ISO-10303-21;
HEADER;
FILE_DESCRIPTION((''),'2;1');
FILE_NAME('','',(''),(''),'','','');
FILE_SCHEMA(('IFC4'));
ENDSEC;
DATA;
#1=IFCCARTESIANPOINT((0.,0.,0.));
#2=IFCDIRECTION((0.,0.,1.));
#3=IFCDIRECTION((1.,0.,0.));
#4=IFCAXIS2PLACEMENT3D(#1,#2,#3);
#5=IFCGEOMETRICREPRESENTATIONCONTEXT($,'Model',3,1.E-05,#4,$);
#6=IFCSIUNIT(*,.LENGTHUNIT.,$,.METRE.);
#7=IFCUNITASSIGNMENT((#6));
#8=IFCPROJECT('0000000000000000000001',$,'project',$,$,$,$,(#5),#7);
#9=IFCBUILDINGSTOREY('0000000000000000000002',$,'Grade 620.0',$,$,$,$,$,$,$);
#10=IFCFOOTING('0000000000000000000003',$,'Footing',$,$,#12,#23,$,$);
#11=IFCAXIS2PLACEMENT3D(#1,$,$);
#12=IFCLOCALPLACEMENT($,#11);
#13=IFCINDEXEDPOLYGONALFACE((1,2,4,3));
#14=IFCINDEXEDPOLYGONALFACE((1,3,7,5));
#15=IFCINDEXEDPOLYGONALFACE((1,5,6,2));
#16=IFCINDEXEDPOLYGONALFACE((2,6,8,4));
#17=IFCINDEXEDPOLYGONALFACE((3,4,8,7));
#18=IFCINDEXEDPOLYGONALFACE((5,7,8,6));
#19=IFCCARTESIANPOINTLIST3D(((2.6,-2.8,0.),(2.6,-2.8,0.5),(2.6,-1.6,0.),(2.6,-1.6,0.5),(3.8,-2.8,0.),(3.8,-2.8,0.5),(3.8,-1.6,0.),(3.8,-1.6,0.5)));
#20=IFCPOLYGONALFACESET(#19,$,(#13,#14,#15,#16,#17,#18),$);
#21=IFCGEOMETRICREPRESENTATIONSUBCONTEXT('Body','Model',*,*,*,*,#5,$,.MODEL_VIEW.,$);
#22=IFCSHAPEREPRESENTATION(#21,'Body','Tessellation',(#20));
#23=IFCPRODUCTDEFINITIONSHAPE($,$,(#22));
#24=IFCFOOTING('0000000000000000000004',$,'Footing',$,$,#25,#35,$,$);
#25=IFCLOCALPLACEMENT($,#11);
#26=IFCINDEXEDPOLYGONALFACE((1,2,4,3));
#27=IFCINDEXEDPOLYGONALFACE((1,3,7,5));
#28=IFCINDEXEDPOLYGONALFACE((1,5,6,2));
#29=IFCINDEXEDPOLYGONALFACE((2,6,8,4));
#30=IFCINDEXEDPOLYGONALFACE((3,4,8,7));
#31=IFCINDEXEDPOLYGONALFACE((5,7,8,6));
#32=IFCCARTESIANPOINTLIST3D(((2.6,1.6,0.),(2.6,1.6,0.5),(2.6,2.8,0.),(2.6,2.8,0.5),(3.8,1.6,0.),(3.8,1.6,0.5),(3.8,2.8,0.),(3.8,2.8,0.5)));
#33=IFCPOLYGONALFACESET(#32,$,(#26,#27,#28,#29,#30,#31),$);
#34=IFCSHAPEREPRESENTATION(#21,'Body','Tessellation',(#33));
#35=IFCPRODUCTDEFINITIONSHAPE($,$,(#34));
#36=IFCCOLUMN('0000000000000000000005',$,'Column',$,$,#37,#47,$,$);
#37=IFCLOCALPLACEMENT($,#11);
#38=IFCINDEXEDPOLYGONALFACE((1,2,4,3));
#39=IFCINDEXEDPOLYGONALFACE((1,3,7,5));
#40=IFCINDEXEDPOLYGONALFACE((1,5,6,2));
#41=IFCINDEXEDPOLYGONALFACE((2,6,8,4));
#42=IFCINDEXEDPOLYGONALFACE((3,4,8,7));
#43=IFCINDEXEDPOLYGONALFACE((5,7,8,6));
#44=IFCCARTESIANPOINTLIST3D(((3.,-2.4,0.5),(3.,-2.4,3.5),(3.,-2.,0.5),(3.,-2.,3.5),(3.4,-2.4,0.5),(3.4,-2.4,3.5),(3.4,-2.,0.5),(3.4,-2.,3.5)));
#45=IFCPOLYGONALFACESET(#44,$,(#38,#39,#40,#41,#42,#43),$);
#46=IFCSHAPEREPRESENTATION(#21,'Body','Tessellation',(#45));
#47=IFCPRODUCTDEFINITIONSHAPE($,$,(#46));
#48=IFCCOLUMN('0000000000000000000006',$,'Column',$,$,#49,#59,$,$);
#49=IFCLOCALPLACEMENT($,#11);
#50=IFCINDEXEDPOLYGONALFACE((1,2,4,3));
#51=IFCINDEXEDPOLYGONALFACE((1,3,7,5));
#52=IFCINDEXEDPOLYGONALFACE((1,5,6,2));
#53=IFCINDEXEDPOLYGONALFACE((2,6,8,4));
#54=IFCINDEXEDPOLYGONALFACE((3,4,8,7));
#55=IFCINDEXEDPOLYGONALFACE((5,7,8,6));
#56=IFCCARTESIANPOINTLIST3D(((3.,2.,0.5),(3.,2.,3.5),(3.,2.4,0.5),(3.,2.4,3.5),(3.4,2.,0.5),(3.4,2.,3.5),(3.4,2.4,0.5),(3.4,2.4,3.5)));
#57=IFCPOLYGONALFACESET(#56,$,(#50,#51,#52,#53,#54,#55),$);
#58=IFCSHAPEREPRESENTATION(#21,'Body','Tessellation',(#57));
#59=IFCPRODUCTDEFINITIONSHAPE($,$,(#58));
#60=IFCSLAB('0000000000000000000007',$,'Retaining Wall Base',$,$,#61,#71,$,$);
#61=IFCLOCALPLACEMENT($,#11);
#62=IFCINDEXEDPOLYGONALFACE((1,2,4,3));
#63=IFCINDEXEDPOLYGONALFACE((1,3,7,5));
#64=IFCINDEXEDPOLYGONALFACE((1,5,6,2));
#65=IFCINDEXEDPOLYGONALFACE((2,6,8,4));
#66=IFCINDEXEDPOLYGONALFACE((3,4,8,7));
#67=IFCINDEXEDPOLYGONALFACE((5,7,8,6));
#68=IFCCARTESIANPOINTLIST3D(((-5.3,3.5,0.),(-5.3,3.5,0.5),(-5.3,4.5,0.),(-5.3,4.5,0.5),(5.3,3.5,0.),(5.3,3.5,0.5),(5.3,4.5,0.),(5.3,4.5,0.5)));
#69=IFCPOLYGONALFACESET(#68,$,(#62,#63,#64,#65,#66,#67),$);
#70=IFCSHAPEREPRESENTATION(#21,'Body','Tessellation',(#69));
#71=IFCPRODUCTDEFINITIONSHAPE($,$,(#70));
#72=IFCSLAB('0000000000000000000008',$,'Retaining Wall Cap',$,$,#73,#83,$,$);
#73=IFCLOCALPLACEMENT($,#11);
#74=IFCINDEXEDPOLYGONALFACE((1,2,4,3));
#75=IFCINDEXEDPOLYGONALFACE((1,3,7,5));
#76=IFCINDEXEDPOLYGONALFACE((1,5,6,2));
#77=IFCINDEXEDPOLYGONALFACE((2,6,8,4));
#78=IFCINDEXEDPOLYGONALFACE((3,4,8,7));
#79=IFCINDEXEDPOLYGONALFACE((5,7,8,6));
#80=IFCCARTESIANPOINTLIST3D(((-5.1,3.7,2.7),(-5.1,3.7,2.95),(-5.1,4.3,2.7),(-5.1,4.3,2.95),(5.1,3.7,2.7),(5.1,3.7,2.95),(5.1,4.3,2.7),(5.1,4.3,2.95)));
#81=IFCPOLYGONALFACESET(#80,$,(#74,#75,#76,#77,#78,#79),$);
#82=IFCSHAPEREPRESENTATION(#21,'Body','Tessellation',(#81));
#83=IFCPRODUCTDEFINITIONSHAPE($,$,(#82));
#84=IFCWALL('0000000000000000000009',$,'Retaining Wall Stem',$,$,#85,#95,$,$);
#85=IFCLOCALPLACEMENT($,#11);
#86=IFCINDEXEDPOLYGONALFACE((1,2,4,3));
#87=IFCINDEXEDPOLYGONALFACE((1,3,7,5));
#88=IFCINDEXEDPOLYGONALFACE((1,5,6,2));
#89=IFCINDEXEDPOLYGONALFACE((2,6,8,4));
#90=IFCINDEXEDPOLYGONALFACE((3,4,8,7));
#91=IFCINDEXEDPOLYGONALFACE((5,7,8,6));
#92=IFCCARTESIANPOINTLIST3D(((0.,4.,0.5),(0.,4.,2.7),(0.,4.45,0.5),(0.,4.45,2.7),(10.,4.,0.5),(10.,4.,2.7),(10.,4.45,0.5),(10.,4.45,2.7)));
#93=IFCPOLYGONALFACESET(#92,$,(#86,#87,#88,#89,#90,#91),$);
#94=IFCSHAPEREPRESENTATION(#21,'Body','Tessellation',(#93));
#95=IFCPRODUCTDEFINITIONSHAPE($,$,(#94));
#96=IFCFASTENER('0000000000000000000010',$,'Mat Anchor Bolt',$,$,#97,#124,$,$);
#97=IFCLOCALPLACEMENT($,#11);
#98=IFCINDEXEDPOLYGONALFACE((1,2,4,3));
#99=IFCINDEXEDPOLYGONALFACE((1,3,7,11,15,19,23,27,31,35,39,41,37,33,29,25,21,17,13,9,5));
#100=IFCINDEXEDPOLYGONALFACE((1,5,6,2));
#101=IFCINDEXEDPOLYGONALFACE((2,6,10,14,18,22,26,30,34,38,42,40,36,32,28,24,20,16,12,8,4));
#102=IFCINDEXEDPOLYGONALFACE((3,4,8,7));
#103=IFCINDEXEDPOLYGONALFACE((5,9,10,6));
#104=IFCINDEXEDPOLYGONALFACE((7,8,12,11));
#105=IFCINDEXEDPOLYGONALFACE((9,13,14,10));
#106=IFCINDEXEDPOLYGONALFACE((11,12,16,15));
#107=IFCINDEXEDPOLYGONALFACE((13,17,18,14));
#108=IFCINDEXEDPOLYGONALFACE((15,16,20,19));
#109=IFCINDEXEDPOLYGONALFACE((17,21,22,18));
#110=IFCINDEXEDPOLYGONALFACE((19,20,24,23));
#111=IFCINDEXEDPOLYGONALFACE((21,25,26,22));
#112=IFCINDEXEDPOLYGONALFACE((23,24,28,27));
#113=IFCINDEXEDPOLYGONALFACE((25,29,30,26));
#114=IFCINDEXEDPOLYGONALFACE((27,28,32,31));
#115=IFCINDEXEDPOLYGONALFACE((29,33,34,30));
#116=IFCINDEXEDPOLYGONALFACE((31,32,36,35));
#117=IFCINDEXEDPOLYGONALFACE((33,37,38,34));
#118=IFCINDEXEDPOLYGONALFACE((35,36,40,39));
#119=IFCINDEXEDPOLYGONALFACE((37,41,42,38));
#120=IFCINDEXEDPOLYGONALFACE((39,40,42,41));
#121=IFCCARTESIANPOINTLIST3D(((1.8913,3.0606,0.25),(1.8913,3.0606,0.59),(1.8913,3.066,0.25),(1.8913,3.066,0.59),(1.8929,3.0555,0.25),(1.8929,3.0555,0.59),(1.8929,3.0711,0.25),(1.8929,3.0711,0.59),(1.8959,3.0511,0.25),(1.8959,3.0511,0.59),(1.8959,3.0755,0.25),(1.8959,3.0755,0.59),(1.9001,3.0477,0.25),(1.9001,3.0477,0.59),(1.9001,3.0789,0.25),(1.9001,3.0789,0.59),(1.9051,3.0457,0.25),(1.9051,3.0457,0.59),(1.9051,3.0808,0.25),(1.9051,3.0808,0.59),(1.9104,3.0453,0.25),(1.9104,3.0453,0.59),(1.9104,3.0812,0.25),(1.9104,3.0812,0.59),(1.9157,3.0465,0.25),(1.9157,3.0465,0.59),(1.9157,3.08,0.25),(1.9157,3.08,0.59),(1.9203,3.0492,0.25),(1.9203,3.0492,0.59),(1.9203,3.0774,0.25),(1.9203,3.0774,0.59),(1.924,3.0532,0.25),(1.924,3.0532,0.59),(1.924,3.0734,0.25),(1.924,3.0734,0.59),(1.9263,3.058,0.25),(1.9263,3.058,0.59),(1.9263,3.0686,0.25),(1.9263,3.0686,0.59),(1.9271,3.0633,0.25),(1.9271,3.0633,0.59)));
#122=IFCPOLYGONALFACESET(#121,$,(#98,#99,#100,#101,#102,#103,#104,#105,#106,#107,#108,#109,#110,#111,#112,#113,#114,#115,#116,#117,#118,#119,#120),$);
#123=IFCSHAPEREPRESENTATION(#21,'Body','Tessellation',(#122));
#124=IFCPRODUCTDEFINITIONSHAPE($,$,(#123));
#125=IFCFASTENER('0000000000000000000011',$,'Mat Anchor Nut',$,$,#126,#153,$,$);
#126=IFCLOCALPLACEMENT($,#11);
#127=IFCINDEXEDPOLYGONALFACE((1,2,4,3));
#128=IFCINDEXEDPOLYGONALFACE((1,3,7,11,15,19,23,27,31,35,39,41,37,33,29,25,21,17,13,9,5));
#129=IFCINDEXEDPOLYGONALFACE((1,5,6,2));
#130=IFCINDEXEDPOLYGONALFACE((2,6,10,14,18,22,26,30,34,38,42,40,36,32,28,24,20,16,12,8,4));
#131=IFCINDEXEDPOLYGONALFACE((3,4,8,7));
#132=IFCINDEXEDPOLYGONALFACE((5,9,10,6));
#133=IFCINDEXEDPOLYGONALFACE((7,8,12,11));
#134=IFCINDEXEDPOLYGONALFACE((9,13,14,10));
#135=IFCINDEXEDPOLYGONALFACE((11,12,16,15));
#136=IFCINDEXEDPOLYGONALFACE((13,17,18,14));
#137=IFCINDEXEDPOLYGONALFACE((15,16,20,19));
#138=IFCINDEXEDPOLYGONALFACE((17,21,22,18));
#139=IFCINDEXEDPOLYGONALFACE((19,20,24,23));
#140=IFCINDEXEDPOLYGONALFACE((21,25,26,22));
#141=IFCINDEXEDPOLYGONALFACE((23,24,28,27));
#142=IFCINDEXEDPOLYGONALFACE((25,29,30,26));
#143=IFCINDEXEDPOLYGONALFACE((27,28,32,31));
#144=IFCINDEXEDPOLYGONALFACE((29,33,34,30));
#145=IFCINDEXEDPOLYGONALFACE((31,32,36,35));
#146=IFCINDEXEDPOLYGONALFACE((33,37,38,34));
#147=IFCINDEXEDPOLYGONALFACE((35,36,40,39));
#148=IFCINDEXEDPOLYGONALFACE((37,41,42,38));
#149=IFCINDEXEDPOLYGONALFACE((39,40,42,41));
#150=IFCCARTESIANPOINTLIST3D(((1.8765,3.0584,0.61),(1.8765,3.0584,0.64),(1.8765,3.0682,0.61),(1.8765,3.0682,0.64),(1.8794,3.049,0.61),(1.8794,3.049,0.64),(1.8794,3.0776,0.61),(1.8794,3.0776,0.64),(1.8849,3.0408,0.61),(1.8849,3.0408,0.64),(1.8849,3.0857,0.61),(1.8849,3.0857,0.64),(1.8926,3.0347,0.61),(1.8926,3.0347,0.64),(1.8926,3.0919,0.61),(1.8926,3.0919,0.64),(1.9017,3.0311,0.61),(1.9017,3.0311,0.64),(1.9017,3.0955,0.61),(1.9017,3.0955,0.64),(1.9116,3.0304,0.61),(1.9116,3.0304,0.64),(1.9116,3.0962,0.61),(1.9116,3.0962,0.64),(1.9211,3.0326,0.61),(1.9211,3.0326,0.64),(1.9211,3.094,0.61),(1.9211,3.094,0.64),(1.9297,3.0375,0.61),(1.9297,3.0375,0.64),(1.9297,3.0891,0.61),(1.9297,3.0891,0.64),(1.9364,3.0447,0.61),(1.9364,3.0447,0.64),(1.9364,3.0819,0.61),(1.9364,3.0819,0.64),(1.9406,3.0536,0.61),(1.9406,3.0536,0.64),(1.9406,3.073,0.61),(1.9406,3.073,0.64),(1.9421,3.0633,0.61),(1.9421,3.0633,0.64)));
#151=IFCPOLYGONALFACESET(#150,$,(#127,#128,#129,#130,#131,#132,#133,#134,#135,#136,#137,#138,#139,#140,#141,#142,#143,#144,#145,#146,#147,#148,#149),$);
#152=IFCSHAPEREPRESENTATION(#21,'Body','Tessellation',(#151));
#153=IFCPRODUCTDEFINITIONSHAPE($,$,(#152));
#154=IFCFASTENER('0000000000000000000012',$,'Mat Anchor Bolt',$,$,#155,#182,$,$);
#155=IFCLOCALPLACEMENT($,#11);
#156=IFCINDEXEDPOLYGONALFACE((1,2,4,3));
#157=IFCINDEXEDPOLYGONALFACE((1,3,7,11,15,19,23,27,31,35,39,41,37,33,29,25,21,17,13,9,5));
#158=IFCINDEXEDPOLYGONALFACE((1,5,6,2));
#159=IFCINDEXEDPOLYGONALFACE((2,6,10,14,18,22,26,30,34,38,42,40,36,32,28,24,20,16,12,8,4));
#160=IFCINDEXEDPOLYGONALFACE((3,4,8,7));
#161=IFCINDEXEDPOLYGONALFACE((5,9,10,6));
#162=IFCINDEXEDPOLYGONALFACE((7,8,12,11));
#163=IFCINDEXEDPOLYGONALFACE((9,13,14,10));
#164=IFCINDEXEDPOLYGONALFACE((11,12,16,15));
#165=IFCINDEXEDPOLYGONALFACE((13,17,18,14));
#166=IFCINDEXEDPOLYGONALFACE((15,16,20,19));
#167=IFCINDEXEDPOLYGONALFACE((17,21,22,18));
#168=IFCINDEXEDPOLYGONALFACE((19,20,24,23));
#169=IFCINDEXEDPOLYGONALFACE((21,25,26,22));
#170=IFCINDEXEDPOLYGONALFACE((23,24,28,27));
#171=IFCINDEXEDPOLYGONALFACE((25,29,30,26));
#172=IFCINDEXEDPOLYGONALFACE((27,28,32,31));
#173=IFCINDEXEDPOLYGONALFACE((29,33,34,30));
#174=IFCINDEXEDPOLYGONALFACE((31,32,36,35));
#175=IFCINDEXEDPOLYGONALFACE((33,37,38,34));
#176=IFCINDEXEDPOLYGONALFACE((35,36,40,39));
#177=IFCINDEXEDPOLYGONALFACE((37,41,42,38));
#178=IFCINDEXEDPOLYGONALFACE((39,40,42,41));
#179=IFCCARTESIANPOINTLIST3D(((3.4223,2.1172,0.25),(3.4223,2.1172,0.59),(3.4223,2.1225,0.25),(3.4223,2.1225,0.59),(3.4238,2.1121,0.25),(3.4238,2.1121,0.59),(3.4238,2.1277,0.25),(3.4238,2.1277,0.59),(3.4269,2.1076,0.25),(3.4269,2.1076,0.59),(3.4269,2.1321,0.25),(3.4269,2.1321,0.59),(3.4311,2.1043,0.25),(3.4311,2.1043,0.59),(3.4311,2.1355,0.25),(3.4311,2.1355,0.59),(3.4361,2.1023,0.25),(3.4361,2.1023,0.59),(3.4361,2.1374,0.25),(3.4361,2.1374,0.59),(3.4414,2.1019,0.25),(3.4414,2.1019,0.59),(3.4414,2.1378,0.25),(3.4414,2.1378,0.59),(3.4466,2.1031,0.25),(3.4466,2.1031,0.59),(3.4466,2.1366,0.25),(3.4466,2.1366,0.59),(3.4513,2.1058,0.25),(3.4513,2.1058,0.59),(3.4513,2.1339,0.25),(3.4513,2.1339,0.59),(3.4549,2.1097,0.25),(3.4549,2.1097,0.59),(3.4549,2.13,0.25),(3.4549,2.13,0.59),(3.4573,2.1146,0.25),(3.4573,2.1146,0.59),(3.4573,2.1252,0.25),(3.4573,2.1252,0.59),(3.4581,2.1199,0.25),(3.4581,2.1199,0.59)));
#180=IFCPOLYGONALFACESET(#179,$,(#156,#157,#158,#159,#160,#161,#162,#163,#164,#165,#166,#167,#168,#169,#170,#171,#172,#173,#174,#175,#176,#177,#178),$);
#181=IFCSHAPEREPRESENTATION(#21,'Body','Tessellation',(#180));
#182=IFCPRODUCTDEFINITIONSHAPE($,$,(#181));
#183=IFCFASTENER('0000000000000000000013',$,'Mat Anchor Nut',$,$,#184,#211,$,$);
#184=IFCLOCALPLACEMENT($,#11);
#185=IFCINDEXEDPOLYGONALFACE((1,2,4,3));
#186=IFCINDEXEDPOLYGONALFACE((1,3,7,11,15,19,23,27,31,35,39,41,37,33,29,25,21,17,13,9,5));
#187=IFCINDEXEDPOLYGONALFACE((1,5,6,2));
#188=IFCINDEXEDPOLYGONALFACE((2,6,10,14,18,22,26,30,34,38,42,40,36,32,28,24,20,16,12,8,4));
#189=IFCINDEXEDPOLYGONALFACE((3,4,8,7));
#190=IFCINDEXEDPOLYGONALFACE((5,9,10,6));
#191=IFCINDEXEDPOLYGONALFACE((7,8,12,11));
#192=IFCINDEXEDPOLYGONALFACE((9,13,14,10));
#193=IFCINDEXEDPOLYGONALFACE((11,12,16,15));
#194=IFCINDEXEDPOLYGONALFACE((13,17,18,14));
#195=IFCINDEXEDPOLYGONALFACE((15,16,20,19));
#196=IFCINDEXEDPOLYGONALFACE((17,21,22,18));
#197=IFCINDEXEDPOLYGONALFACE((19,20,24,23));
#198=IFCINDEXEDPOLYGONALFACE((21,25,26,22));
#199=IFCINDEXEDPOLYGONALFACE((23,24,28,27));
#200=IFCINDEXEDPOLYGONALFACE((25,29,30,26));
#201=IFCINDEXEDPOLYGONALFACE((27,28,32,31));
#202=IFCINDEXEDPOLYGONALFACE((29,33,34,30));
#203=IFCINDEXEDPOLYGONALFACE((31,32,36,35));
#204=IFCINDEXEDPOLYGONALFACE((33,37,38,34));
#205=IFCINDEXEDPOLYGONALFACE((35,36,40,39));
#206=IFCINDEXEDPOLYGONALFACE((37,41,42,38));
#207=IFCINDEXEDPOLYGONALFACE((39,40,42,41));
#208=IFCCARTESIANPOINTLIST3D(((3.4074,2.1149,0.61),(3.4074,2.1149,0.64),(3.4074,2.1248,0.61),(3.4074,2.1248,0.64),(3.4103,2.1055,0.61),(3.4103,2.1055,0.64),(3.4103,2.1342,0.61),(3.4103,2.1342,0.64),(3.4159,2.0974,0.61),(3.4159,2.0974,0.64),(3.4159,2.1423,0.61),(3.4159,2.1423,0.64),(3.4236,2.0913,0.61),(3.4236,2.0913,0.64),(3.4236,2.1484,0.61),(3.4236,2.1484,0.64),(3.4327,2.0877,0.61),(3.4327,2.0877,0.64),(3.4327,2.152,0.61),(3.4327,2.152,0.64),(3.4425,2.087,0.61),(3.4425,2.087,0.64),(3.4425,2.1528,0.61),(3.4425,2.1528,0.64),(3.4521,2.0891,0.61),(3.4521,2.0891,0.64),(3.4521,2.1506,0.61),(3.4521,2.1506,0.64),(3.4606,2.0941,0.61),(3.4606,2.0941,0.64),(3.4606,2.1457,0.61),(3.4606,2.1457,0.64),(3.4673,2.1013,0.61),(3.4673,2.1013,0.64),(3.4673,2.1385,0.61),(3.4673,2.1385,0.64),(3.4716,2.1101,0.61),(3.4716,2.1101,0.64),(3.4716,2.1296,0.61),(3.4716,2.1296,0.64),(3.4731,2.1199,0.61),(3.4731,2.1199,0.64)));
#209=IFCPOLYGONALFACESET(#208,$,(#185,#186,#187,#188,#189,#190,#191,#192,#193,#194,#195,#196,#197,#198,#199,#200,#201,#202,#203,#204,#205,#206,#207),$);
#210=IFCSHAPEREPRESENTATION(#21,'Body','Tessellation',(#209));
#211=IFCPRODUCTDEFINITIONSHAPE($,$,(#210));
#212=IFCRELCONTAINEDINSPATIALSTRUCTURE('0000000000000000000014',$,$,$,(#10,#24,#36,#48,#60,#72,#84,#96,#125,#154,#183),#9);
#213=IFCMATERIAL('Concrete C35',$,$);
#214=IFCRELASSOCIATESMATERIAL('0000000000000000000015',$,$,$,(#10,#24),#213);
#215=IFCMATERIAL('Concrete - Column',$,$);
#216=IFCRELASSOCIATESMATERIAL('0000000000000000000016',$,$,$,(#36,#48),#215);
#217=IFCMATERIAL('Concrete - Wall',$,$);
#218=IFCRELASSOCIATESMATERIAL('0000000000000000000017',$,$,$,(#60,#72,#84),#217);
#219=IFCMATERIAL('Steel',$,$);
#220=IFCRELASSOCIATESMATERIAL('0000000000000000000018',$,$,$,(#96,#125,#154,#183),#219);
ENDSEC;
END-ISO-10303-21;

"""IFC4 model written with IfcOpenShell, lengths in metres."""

from ifc_helpers import new_model, si_unit, frame, origin_with_axes, place, context, subcontext, project, spatial, indexed_curve, rectangle, circle, outline, extrude, material, element, save


model = new_model("IFC4")

# Units and contexts
model_context = context("Model", 3, precision=1e-05, world=origin_with_axes())
body_context = subcontext(model_context, "Body", "Model", "MODEL_VIEW")
ifc_project = project(units=[si_unit("LENGTHUNIT", "METRE")], contexts=[model_context])

# Storey
storey = spatial("IfcBuildingStorey", Name="Grade 620.0")

# Footings
ifc_material_1 = material(Name="Concrete C35")
for number, where, z_axis, x_axis, name in (
    (1, (3.2, -2.2, 0.0), (0.0, 0.0, 1.0), (1.0, 0.0, 0.0), "Footing"),
    (2, (3.2, 2.2, 0.0), (0.0, 0.0, 1.0), (1.0, 0.0, 0.0), "Footing"),
):
    element("IfcFooting", number, at=place(None, frame(where, z_axis=z_axis, x_axis=x_axis)), inside=storey, material=ifc_material_1, Name=name, context=body_context, shape_type="SweptSolid", body=[
        extrude(rectangle(XDim=1.2, YDim=1.2), origin_with_axes(), (0.0, 0.0, 1.0), 0.5),
    ])

# Columns
ifc_material_2 = material(Name="Concrete - Column")
for number, where, z_axis, x_axis, name in (
    (3, (3.2, -2.2, 0.5), (0.0, 0.0, 1.0), (1.0, 0.0, 0.0), "Column"),
    (4, (3.2, 2.2, 0.5), (0.0, 0.0, 1.0), (1.0, 0.0, 0.0), "Column"),
):
    element("IfcColumn", number, at=place(None, frame(where, z_axis=z_axis, x_axis=x_axis)), inside=storey, material=ifc_material_2, Name=name, context=body_context, shape_type="SweptSolid", body=[
        extrude(rectangle(XDim=0.4, YDim=0.4), origin_with_axes(), (0.0, 0.0, 1.0), 3.0),
    ])

# Slabs
ifc_material_3 = material(Name="Concrete - Wall")
slab_1_placement = place(None, frame((0.0, 4.0, 0.0), z_axis=(0.0, 0.0, 1.0), x_axis=(1.0, 0.0, 0.0)))
element("IfcSlab", 5, at=slab_1_placement, inside=storey, material=ifc_material_3, Name="Retaining Wall Base", context=body_context, shape_type="SweptSolid", body=[
    extrude(rectangle(XDim=10.6, YDim=1.0), origin_with_axes(), (0.0, 0.0, 1.0), 0.5),
])
slab_2_placement = place(None, frame((0.0, 4.0, 2.7), z_axis=(0.0, 0.0, 1.0), x_axis=(1.0, 0.0, 0.0)))
element("IfcSlab", 6, at=slab_2_placement, inside=storey, material=ifc_material_3, Name="Retaining Wall Cap", context=body_context, shape_type="SweptSolid", body=[
    extrude(rectangle(XDim=10.2, YDim=0.6), origin_with_axes(), (0.0, 0.0, 1.0), 0.25),
])

# Wall
wall_placement = place(None, frame((0.0, 4.0, 0.5), z_axis=(0.0, 0.0, 1.0), x_axis=(1.0, 0.0, 0.0)))
element("IfcWall", 7, at=wall_placement, inside=storey, material=ifc_material_3, Name="Retaining Wall Stem", context=body_context, shape_type="SweptSolid", body=[
    extrude(outline(indexed_curve([(0.0, 0.0), (0.0, 0.45), (10.0, 0.45), (10.0, 0.0), (0.0, 0.0)], self_intersect=False)), origin_with_axes(), (0.0, 0.0, 1.0), 2.2),
])

# Fasteners
ifc_material_4 = material(Name="Steel")
fastener_1_placement = place(None, frame((1.9091, 3.0633, 0.25), z_axis=(0.0, 0.0, 1.0), x_axis=(1.0, 0.0, 0.0)))
element("IfcFastener", 8, at=fastener_1_placement, inside=storey, material=ifc_material_4, Name="Mat Anchor Bolt", context=body_context, shape_type="SweptSolid", body=[
    extrude(circle(Radius=0.018), origin_with_axes(), (0.0, 0.0, 1.0), 0.34),
])
fastener_2_placement = place(None, frame((1.9091, 3.0633, 0.61), z_axis=(0.0, 0.0, 1.0), x_axis=(1.0, 0.0, 0.0)))
element("IfcFastener", 9, at=fastener_2_placement, inside=storey, material=ifc_material_4, Name="Mat Anchor Nut", context=body_context, shape_type="SweptSolid", body=[
    extrude(circle(Radius=0.033), origin_with_axes(), (0.0, 0.0, 1.0), 0.03),
])
fastener_3_placement = place(None, frame((3.4401, 2.1199, 0.25), z_axis=(0.0, 0.0, 1.0), x_axis=(1.0, 0.0, 0.0)))
element("IfcFastener", 10, at=fastener_3_placement, inside=storey, material=ifc_material_4, Name="Mat Anchor Bolt", context=body_context, shape_type="SweptSolid", body=[
    extrude(circle(Radius=0.018), origin_with_axes(), (0.0, 0.0, 1.0), 0.34),
])
fastener_4_placement = place(None, frame((3.4401, 2.1199, 0.61), z_axis=(0.0, 0.0, 1.0), x_axis=(1.0, 0.0, 0.0)))
element("IfcFastener", 11, at=fastener_4_placement, inside=storey, material=ifc_material_4, Name="Mat Anchor Nut", context=body_context, shape_type="SweptSolid", body=[
    extrude(circle(Radius=0.033), origin_with_axes(), (0.0, 0.0, 1.0), 0.03),
])

save(model, "model.ifc")
